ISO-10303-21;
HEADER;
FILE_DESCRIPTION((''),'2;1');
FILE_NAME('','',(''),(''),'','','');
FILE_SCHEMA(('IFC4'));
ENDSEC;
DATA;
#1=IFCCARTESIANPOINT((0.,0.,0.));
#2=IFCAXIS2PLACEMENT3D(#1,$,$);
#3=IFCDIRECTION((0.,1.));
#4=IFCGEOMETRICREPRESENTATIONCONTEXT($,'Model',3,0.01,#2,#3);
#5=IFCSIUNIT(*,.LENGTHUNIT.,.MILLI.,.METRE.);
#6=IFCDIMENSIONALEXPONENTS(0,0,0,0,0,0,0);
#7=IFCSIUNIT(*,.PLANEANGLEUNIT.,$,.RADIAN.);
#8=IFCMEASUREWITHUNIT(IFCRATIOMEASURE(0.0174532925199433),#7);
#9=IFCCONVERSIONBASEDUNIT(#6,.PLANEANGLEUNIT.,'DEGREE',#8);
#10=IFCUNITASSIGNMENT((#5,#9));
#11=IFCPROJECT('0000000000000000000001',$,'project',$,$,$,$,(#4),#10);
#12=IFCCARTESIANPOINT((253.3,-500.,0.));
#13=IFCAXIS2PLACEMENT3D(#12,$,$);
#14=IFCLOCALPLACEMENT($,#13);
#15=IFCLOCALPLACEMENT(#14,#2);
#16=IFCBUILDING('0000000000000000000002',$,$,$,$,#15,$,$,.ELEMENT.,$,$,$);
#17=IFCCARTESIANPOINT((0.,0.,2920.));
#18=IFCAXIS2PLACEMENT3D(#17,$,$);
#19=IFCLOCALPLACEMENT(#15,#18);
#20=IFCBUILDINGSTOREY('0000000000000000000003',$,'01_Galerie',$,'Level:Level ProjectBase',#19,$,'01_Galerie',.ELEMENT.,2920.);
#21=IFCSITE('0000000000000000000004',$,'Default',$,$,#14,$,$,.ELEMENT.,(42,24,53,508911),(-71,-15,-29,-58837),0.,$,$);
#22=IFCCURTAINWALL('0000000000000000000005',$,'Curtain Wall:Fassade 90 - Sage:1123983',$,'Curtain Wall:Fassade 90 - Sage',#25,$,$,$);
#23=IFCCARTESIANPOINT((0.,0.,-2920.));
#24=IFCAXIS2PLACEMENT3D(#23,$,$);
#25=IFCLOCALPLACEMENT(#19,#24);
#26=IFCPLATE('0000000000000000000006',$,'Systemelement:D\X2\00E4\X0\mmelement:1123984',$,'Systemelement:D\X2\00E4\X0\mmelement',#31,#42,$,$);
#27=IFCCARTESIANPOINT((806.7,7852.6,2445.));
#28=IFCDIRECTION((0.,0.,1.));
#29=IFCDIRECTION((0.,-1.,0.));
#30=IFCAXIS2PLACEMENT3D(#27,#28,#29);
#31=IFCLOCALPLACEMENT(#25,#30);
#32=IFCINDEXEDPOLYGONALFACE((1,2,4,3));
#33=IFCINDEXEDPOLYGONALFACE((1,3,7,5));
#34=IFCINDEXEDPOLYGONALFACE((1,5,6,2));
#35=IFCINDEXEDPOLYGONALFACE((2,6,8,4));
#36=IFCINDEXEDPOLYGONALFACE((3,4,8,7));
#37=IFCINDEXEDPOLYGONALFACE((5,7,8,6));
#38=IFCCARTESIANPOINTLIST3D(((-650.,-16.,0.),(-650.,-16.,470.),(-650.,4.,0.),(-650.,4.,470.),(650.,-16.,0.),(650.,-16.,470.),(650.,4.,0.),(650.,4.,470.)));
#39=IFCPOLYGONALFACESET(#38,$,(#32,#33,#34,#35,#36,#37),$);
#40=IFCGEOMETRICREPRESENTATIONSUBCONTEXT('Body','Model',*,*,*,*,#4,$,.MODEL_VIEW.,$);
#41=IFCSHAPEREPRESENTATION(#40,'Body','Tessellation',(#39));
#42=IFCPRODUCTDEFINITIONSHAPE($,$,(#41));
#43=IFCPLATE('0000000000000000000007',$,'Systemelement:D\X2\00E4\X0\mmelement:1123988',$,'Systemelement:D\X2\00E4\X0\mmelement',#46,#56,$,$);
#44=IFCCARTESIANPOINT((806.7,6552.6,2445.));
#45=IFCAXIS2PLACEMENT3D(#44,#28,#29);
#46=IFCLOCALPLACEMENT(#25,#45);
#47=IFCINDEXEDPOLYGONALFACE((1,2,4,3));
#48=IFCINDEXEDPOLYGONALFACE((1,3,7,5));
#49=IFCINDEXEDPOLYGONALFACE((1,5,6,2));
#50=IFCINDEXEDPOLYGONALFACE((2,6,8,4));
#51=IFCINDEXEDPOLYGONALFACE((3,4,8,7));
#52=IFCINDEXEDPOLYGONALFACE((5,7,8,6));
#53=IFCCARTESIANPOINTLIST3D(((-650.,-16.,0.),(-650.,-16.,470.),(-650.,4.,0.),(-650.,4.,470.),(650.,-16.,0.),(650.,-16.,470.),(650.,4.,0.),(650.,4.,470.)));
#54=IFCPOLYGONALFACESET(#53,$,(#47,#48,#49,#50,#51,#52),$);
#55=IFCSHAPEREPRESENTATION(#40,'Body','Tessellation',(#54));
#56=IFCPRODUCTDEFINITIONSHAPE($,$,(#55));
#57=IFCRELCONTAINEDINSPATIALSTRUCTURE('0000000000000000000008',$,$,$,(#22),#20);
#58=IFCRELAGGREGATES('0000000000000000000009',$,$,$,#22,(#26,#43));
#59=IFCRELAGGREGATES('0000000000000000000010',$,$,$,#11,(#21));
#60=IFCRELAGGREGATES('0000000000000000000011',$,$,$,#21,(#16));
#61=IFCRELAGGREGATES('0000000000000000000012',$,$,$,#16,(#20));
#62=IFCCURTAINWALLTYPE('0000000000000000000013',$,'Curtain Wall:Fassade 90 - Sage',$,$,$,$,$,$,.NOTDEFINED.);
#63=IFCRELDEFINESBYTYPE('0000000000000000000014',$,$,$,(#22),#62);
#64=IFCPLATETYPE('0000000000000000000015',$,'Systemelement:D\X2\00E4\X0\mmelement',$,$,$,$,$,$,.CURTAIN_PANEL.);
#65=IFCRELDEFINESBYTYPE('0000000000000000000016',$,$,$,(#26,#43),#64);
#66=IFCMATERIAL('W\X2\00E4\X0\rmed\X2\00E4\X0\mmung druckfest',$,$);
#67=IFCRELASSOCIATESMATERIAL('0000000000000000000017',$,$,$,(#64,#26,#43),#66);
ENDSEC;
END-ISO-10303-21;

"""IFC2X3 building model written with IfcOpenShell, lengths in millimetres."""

from ifc_helpers import new_model, entity, si_unit, converted_unit, direction, frame, origin, origin_2d_with_axis, place, context, subcontext, project, spatial, rectangle, extrude, source, transform, mapped, material, type_object, type_shapes, element, aggregate, save


model = new_model("IFC2X3")

# Units and contexts
model_context = context("Model", 3, precision=0.01, world=origin(), true_north=direction((0.0, 1.0)))
body_context = subcontext(model_context, "Body", "Model", "MODEL_VIEW")
ifc_project = project(units=[si_unit("LENGTHUNIT", "METRE", prefix="MILLI"), converted_unit("PLANEANGLEUNIT", "DEGREE", entity("IfcRatioMeasure", 0.0174532925199433), si_unit("PLANEANGLEUNIT", "RADIAN"), dimensions=[0, 0, 0, 0, 0, 0, 0])], contexts=[model_context])

# Site, building, storey
site_placement = place(None, frame((253.3, -500.0, 0.0)))
site = spatial("IfcSite", under=ifc_project, at=site_placement, Name="Default", CompositionType="ELEMENT", RefLatitude=(42, 24, 53, 508911), RefLongitude=(-71, -15, -29, -58837), RefElevation=0.0)
building_placement = place(site_placement, origin())
building = spatial("IfcBuilding", under=site, at=building_placement, CompositionType="ELEMENT")
storey_placement = place(building_placement, frame((0.0, 0.0, 2920.0)))
storey = spatial("IfcBuildingStorey", under=building, at=storey_placement, Name="01_Galerie", ObjectType="Level:Level ProjectBase", LongName="01_Galerie", CompositionType="ELEMENT", Elevation=2920.0)

# Curtain wall, plates
curtain_wall_type_1 = type_object("IfcCurtainWallType", Name="Curtain Wall:Fassade 90 - Sage", PredefinedType="NOTDEFINED")
curtain_wall_1_placement = place(storey_placement, frame((0.0, 0.0, -2920.0)))
curtain_wall_1 = element("IfcCurtainWall", 1, at=curtain_wall_1_placement, inside=storey, type_object=curtain_wall_type_1, Name="Curtain Wall:Fassade 90 - Sage:1123983", ObjectType="Curtain Wall:Fassade 90 - Sage")
ifc_material_1 = material(Name="Wärmedämmung druckfest")
plate_type_1 = type_object("IfcPlateType", Name="Systemelement:Dämmelement", PredefinedType="CURTAIN_PANEL", material=ifc_material_1)
shared_shape_1 = source(origin(), body_context, "Body", "SweptSolid", [
    extrude(rectangle(XDim=20.0, YDim=1300.0, at=origin_2d_with_axis()), frame((0.0, -6.0, 0.0), z_axis=(0.0, 0.0, 1.0), x_axis=(0.0, 1.0, 0.0)), (0.0, 0.0, 1.0), 470.0),
])
type_shapes(plate_type_1, [shared_shape_1])
plate_1_placement = place(curtain_wall_1_placement, frame((806.7, 7852.6, 2445.0), z_axis=(0.0, 0.0, 1.0), x_axis=(0.0, -1.0, 0.0)))
plate_1 = element("IfcPlate", 2, at=plate_1_placement, type_object=plate_type_1, material=ifc_material_1, Name="Systemelement:Dämmelement:1123984", ObjectType="Systemelement:Dämmelement", context=body_context, shape_type="MappedRepresentation", body=[
    mapped(shared_shape_1, transform((0.0, 0.0, 0.0), scale=1.0)),
])
plate_2_placement = place(curtain_wall_1_placement, frame((806.7, 6552.6, 2445.0), z_axis=(0.0, 0.0, 1.0), x_axis=(0.0, -1.0, 0.0)))
plate_2 = element("IfcPlate", 3, at=plate_2_placement, type_object=plate_type_1, material=ifc_material_1, Name="Systemelement:Dämmelement:1123988", ObjectType="Systemelement:Dämmelement", context=body_context, shape_type="MappedRepresentation", body=[
    mapped(shared_shape_1, transform((0.0, 0.0, 0.0), scale=1.0)),
])

aggregate(curtain_wall_1, [plate_1, plate_2])

save(model, "model.ifc")
